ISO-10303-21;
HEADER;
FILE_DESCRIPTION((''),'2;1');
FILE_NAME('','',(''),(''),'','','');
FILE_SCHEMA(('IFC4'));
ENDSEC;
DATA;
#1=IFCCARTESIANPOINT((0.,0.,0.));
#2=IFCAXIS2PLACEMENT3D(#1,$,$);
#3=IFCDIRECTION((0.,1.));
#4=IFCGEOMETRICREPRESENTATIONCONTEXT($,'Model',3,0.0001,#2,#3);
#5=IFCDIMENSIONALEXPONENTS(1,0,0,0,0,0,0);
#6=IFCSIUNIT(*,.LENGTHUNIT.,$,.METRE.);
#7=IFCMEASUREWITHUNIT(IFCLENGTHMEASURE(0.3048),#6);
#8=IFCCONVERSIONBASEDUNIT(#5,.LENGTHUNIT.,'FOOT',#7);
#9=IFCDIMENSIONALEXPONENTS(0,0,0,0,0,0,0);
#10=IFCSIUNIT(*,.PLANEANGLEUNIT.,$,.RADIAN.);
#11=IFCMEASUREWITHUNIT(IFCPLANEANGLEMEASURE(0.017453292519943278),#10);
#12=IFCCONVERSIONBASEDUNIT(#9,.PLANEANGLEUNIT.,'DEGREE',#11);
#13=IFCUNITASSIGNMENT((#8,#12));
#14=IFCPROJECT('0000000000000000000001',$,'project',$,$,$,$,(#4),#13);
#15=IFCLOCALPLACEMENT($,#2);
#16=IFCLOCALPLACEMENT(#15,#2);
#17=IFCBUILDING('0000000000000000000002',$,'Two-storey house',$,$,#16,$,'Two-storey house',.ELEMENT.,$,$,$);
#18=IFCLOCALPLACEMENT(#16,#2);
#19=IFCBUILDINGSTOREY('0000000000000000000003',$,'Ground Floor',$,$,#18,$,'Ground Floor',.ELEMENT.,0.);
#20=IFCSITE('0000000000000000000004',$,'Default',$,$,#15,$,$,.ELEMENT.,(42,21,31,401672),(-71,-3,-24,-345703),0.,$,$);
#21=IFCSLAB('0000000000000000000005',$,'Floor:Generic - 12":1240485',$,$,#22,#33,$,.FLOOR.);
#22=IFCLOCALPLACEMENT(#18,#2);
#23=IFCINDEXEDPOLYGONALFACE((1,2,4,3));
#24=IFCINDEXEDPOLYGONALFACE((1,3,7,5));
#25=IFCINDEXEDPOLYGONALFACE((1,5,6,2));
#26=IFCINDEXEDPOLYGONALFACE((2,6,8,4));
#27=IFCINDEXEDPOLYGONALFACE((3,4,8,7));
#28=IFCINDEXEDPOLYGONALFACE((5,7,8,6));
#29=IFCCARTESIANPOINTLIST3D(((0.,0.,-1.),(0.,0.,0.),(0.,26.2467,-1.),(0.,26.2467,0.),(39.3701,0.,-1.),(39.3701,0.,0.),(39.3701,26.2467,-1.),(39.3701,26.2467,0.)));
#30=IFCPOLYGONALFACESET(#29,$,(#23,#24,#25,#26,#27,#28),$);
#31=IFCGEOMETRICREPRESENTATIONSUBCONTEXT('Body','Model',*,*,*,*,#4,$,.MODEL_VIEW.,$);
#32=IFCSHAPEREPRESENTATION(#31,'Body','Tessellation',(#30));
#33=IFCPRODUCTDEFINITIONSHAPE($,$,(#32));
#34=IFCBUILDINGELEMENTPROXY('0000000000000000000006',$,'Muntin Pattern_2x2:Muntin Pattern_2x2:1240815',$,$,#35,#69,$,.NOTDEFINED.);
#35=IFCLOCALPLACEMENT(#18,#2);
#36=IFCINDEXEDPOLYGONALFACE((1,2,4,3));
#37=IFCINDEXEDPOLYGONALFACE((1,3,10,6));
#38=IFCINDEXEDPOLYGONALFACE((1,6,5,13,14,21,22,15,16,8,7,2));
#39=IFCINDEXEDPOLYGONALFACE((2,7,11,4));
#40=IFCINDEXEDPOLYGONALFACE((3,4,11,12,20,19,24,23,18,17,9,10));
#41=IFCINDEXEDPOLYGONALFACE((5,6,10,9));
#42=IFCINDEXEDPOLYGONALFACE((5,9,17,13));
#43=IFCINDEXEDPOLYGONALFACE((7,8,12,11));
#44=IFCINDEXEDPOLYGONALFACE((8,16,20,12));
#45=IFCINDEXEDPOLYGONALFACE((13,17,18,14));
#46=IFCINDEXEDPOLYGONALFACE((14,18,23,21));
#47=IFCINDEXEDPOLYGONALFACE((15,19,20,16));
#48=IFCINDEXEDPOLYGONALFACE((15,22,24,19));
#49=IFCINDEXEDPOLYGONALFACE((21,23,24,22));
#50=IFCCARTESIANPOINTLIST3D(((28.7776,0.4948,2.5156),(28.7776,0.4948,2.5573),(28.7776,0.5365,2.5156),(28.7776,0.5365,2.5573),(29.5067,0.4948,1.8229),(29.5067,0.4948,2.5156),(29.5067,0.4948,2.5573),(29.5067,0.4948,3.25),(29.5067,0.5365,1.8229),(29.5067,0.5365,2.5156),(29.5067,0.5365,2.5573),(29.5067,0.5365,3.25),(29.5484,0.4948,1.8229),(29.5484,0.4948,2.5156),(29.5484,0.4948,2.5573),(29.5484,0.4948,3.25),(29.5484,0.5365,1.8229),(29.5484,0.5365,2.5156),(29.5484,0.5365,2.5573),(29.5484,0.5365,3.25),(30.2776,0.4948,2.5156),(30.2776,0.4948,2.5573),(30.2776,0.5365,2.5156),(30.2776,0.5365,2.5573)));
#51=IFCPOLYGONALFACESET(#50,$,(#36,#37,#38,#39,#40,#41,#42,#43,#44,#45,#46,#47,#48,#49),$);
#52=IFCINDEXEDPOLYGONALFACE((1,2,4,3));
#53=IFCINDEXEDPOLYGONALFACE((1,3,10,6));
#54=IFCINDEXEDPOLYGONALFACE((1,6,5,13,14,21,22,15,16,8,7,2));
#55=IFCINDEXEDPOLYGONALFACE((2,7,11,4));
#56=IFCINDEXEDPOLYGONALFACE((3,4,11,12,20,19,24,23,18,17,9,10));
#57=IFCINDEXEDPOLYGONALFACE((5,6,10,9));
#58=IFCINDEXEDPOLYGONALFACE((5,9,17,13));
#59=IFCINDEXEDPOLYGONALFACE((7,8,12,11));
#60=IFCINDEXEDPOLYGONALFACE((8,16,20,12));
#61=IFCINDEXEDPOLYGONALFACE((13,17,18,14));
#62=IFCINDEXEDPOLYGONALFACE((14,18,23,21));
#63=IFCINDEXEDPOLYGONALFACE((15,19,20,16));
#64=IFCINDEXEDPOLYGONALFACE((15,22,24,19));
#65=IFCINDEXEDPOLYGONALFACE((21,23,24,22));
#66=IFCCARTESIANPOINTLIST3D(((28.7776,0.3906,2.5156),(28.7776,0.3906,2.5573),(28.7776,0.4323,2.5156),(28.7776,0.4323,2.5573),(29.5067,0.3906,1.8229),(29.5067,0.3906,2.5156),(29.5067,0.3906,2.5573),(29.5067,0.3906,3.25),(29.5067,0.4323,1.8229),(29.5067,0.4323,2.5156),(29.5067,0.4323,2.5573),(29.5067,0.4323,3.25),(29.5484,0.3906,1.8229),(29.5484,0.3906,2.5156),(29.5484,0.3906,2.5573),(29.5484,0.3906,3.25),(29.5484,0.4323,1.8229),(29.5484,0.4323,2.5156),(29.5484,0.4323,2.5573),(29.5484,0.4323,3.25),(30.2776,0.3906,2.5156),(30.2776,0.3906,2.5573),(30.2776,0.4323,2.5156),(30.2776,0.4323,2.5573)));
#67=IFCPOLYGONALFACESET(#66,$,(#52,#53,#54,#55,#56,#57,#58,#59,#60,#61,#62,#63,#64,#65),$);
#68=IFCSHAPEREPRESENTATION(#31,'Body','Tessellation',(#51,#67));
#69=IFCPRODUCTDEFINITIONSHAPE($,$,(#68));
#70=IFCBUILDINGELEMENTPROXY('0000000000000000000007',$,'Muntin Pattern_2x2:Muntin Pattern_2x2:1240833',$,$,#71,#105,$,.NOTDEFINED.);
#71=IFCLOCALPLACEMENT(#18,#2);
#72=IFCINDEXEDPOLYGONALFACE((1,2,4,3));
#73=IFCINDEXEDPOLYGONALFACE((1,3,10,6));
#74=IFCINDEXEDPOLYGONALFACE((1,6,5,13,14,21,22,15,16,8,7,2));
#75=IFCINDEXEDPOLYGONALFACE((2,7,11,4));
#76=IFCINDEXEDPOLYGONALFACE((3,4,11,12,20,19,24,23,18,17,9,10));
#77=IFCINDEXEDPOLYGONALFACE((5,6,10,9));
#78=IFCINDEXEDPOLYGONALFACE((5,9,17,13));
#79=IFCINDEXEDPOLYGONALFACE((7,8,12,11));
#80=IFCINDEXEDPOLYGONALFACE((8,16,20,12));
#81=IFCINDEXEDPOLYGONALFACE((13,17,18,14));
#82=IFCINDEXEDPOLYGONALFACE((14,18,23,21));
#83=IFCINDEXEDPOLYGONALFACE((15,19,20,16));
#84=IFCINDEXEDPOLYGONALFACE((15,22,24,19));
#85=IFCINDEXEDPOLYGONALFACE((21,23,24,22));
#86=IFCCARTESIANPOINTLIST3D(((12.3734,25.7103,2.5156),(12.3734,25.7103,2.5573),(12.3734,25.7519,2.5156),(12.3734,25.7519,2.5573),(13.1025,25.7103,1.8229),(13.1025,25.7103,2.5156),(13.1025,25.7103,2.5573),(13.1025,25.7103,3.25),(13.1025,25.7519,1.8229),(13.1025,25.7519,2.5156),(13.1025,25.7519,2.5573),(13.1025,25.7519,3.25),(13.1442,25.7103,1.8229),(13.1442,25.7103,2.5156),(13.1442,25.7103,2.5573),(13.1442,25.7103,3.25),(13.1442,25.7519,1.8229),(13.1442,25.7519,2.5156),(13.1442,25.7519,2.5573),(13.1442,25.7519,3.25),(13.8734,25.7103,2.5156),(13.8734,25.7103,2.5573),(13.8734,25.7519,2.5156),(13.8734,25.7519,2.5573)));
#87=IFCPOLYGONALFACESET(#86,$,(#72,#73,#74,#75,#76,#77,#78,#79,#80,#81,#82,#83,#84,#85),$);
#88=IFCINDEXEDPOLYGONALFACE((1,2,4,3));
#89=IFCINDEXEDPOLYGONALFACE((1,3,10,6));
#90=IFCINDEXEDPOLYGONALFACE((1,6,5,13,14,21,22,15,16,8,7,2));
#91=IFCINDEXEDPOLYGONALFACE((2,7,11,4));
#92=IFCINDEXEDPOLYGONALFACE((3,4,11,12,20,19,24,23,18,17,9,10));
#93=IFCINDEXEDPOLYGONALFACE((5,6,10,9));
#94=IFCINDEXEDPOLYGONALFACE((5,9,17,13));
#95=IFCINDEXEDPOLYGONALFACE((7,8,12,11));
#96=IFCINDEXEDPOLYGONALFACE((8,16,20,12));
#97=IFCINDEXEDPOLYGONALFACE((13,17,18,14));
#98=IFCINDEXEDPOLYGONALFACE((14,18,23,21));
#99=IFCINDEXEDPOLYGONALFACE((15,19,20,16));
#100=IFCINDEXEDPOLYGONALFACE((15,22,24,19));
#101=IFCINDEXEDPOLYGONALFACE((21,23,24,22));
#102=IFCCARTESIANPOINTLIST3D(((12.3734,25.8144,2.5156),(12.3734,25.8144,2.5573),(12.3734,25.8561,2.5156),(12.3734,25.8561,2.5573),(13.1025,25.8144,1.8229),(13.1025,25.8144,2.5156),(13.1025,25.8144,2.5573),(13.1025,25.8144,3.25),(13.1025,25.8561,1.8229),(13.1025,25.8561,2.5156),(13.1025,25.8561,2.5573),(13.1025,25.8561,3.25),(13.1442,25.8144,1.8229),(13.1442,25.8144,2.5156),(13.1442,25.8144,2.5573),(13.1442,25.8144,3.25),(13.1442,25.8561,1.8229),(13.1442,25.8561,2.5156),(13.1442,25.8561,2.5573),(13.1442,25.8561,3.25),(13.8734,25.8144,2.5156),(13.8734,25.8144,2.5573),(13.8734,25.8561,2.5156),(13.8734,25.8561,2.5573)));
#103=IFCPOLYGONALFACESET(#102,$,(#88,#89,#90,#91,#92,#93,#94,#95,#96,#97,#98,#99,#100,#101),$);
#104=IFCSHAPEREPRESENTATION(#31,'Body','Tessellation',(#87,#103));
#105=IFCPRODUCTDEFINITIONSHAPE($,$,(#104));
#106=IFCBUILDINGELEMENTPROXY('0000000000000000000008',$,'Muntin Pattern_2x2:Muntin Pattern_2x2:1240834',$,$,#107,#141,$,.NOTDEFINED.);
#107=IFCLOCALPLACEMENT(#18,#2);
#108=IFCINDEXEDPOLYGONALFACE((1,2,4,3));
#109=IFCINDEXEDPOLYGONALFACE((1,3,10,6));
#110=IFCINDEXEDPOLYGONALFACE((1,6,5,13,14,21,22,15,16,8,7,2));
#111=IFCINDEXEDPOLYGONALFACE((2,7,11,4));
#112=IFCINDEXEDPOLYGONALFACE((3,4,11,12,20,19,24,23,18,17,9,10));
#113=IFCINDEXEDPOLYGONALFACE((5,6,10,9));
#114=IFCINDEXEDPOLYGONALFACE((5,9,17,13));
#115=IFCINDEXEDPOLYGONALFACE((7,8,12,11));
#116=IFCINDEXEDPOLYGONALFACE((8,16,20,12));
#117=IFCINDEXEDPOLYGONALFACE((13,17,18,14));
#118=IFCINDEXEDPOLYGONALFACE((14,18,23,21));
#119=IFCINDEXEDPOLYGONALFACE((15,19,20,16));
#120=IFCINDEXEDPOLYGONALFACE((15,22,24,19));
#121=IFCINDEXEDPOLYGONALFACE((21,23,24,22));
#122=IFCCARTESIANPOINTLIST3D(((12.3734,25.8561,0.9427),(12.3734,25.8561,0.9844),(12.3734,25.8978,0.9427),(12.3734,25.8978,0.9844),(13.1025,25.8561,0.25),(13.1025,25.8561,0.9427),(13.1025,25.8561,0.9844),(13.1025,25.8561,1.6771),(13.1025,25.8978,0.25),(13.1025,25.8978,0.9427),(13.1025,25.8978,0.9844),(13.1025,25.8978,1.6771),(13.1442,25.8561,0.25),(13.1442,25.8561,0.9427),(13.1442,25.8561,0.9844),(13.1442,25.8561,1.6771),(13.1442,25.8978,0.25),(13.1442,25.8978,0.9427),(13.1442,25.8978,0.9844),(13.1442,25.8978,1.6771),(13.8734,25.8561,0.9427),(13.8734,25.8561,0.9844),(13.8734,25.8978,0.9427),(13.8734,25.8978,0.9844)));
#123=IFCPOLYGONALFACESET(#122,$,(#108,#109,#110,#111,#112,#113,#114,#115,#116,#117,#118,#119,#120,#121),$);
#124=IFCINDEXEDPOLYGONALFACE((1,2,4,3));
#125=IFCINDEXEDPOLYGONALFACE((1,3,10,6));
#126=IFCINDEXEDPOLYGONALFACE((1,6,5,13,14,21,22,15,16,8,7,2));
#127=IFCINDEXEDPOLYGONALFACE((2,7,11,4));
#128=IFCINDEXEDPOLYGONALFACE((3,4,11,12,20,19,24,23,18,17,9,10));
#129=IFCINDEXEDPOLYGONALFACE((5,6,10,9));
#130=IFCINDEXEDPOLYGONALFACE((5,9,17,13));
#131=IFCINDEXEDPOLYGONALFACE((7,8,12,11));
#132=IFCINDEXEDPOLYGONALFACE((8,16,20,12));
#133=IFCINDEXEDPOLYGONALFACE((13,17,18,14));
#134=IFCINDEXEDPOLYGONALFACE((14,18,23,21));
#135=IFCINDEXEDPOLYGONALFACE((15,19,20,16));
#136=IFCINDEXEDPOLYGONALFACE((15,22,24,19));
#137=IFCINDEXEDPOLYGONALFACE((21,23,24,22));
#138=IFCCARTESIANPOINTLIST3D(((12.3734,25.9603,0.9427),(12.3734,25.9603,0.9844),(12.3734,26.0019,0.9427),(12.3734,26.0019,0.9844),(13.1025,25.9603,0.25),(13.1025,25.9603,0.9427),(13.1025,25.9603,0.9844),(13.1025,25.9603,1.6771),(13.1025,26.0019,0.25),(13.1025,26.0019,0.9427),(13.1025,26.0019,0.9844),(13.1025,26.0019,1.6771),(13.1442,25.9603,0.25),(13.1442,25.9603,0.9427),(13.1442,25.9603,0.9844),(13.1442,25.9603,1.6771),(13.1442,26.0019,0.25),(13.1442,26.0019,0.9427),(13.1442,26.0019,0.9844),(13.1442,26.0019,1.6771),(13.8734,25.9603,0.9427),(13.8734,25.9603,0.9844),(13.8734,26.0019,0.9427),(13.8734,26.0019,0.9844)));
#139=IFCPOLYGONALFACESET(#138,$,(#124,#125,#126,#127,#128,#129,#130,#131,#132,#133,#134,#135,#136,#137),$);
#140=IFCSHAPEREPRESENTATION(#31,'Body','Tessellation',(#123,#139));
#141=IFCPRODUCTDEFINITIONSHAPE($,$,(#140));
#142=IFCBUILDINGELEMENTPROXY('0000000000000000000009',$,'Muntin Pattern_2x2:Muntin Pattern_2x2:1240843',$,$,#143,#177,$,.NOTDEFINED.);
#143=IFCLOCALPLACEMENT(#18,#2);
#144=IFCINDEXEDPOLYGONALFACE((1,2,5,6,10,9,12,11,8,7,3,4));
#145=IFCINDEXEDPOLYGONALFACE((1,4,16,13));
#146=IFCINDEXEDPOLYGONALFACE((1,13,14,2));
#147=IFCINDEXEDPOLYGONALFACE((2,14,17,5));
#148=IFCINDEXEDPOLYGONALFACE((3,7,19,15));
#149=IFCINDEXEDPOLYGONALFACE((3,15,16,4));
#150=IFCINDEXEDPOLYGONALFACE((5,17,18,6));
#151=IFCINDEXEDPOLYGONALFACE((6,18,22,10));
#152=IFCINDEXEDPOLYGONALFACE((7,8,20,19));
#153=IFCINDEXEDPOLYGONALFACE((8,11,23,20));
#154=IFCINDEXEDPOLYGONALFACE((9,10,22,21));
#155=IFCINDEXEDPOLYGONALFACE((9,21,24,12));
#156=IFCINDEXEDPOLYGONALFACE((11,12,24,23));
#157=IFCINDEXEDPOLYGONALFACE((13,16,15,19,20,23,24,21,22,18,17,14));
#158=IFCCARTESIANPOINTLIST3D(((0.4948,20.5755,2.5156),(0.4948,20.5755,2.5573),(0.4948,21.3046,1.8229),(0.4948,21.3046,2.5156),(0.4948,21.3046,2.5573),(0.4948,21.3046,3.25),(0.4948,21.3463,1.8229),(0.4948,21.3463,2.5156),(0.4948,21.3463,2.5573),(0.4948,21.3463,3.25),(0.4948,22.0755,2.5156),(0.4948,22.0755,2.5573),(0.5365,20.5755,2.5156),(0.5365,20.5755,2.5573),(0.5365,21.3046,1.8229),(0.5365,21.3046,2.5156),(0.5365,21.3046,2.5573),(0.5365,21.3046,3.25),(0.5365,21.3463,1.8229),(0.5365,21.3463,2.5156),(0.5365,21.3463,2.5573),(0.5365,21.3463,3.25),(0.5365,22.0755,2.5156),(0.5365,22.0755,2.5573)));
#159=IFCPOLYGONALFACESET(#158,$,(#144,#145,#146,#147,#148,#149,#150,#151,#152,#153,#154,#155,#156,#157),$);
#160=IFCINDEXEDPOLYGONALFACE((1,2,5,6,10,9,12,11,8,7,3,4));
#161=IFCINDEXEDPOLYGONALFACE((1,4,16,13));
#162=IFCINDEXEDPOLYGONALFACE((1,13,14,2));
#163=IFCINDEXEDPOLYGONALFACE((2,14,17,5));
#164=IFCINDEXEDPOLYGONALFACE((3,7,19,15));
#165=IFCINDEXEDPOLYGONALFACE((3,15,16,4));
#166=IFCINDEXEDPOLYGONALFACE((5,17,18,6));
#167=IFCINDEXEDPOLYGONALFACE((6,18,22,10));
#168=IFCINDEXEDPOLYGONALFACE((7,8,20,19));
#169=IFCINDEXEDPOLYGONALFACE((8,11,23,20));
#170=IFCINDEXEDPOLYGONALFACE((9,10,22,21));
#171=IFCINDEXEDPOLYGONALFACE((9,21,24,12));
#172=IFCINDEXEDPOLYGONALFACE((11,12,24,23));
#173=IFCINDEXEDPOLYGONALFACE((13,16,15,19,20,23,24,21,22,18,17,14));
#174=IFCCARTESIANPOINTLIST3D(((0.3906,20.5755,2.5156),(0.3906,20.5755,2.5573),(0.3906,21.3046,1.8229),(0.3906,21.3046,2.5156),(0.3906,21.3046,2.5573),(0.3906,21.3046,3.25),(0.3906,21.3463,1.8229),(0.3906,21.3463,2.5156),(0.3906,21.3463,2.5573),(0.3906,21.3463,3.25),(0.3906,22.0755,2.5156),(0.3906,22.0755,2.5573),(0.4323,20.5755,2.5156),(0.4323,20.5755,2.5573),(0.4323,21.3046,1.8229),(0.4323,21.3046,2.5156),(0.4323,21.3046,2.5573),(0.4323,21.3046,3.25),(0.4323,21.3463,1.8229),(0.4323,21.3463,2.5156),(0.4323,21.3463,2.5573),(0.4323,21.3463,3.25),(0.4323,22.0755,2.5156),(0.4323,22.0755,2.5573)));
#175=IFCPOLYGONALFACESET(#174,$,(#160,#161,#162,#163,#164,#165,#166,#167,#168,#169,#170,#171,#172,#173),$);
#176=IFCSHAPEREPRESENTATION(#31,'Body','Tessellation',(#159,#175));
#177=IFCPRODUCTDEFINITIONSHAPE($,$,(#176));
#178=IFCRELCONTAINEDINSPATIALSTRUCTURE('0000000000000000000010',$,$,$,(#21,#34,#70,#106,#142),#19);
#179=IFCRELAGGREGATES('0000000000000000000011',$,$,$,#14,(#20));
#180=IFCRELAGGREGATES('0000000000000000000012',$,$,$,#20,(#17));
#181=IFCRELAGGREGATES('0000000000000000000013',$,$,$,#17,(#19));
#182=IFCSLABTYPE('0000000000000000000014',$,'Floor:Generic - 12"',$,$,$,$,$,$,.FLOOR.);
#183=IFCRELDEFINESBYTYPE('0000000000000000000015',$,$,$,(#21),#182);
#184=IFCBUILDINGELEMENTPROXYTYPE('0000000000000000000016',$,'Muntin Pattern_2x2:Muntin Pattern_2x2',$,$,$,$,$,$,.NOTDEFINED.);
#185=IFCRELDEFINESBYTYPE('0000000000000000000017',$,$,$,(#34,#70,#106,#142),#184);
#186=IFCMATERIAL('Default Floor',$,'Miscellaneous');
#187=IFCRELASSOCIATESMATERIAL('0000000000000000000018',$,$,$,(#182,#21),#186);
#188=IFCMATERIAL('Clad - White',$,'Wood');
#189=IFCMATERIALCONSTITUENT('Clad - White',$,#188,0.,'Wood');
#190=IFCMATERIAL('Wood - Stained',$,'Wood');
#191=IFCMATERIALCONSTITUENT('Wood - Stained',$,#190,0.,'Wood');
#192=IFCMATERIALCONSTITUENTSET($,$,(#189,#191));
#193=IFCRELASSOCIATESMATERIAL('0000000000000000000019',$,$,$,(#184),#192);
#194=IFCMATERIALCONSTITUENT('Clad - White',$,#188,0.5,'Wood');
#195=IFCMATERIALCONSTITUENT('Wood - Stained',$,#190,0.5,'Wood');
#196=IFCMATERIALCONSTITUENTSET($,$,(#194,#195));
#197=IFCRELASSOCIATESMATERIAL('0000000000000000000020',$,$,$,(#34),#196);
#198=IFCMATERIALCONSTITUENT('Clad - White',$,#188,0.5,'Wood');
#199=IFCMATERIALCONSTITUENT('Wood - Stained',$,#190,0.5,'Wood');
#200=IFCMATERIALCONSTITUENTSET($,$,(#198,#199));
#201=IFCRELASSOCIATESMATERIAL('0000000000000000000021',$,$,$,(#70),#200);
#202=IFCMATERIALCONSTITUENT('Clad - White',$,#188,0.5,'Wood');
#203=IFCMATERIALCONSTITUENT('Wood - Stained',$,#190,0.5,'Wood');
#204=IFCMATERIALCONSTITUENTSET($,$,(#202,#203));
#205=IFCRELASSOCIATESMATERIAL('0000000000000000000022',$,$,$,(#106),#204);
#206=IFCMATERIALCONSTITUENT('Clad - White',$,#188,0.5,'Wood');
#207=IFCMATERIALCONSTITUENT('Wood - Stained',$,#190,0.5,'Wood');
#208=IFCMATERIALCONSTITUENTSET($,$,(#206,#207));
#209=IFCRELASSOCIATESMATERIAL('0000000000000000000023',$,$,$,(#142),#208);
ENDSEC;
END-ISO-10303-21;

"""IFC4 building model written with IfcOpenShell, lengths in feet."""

from ifc_helpers import new_model, entity, si_unit, converted_unit, direction, frame, origin, place, context, subcontext, project, spatial, indexed_curve, outline, extrude, source, transform, mapped, material, constituent, constituent_set, type_object, type_shapes, element, save


model = new_model("IFC4")

# Units and contexts
model_context = context("Model", 3, precision=0.0001, world=origin(), true_north=direction((0.0, 1.0)))
body_context = subcontext(model_context, "Body", "Model", "MODEL_VIEW")
ifc_project = project(units=[converted_unit("LENGTHUNIT", "FOOT", entity("IfcLengthMeasure", 0.3048), si_unit("LENGTHUNIT", "METRE"), dimensions=[1, 0, 0, 0, 0, 0, 0]), converted_unit("PLANEANGLEUNIT", "DEGREE", entity("IfcPlaneAngleMeasure", 0.017453292519943278), si_unit("PLANEANGLEUNIT", "RADIAN"), dimensions=[0, 0, 0, 0, 0, 0, 0])], contexts=[model_context])

# Site, building, storey
site_placement = place(None, origin())
site = spatial("IfcSite", under=ifc_project, at=site_placement, Name="Default", CompositionType="ELEMENT", RefLatitude=(42, 21, 31, 401672), RefLongitude=(-71, -3, -24, -345703), RefElevation=0.0)
building_placement = place(site_placement, origin())
building = spatial("IfcBuilding", under=site, at=building_placement, Name="Two-storey house", LongName="Two-storey house", CompositionType="ELEMENT")
storey_placement = place(building_placement, origin())
storey = spatial("IfcBuildingStorey", under=building, at=storey_placement, Name="Ground Floor", LongName="Ground Floor", CompositionType="ELEMENT", Elevation=0.0)

# Slab
ifc_material_1 = material(Name="Default Floor", Category="Miscellaneous")
slab_type = type_object("IfcSlabType", Name="Floor:Generic - 12\"", PredefinedType="FLOOR", material=ifc_material_1)
slab_placement = place(storey_placement, origin())
element("IfcSlab", 1, at=slab_placement, inside=storey, type_object=slab_type, material=ifc_material_1, Name="Floor:Generic - 12\":1240485", PredefinedType="FLOOR", context=body_context, shape_type="SweptSolid", body=[
    extrude(outline(indexed_curve([(-13.1234, -19.685), (13.1234, -19.685), (13.1234, 19.685), (-13.1234, 19.685), (-13.1234, -19.685)], self_intersect=False)), frame((19.685, 13.1234, 0.0), z_axis=(0.0, 0.0, -1.0), x_axis=(0.0, 1.0, 0.0)), (0.0, 0.0, 1.0), 1.0),
])

# Shared definitions
ifc_material_2 = material(Name="Wood - Stained", Category="Wood")

# Building element proxies
ifc_material_3 = material(Name="Clad - White", Category="Wood")
ifc_constituent_1 = constituent(ifc_material_3, Name="Clad - White", Category="Wood", fraction=0.5)
ifc_constituent_2 = constituent(ifc_material_2, Name="Wood - Stained", Category="Wood", fraction=0.5)
ifc_constituent_set_1 = constituent_set(constituents=[ifc_constituent_1, ifc_constituent_2])
ifc_constituent_3 = constituent(ifc_material_3, Name="Clad - White", Category="Wood", fraction=0.0)
ifc_constituent_4 = constituent(ifc_material_2, Name="Wood - Stained", Category="Wood", fraction=0.0)
ifc_constituent_set_2 = constituent_set(constituents=[ifc_constituent_3, ifc_constituent_4])
building_element_proxy_type_1 = type_object("IfcBuildingElementProxyType", Name="Muntin Pattern_2x2:Muntin Pattern_2x2", PredefinedType="NOTDEFINED", material=ifc_constituent_set_2)
shared_shape_1 = source(origin(), body_context, "Body", "SweptSolid", [
    extrude(outline(indexed_curve([(0.0208, -0.0208), (0.7135, -0.0208), (0.7135, 0.0208), (0.0208, 0.0208), (0.0208, 0.75), (-0.0208, 0.75), (-0.0208, 0.0208), (-0.7135, 0.0208), (-0.7135, -0.0208), (-0.0208, -0.0208), (-0.0208, -0.75), (0.0208, -0.75), (0.0208, -0.0208)], self_intersect=False)), frame((0.0, 0.0312, 0.7135), z_axis=(0.0, 1.0, 0.0), x_axis=(0.0, 0.0, 1.0)), (0.0, 0.0, 1.0), 0.0417),
    extrude(outline(indexed_curve([(0.0208, -0.0208), (0.7135, -0.0208), (0.7135, 0.0208), (0.0208, 0.0208), (0.0208, 0.75), (-0.0208, 0.75), (-0.0208, 0.0208), (-0.7135, 0.0208), (-0.7135, -0.0208), (-0.0208, -0.0208), (-0.0208, -0.75), (0.0208, -0.75), (0.0208, -0.0208)], self_intersect=False)), frame((0.0, -0.0729, 0.7135), z_axis=(0.0, 1.0, 0.0), x_axis=(0.0, 0.0, 1.0)), (0.0, 0.0, 1.0), 0.0417),
])
type_shapes(building_element_proxy_type_1, [shared_shape_1])
proxy_1_placement = place(storey_placement, frame((29.5276, 0.4635, 1.8229)))
element("IfcBuildingElementProxy", 2, at=proxy_1_placement, inside=storey, type_object=building_element_proxy_type_1, material=ifc_constituent_set_1, Name="Muntin Pattern_2x2:Muntin Pattern_2x2:1240815", PredefinedType="NOTDEFINED", context=body_context, shape_type="MappedRepresentation", body=[
    mapped(shared_shape_1, transform((0.0, 0.0, 0.0), scale=1.0)),
])
ifc_constituent_5 = constituent(ifc_material_3, Name="Clad - White", Category="Wood", fraction=0.5)
ifc_constituent_6 = constituent(ifc_material_2, Name="Wood - Stained", Category="Wood", fraction=0.5)
ifc_constituent_set_3 = constituent_set(constituents=[ifc_constituent_5, ifc_constituent_6])
proxy_2_placement = place(storey_placement, frame((13.1234, 25.7832, 1.8229), z_axis=(0.0, 0.0, 1.0), x_axis=(-1.0, 0.0, 0.0)))
element("IfcBuildingElementProxy", 3, at=proxy_2_placement, inside=storey, type_object=building_element_proxy_type_1, material=ifc_constituent_set_3, Name="Muntin Pattern_2x2:Muntin Pattern_2x2:1240833", PredefinedType="NOTDEFINED", context=body_context, shape_type="MappedRepresentation", body=[
    mapped(shared_shape_1, transform((0.0, 0.0, 0.0), scale=1.0)),
])
ifc_constituent_7 = constituent(ifc_material_3, Name="Clad - White", Category="Wood", fraction=0.5)
ifc_constituent_8 = constituent(ifc_material_2, Name="Wood - Stained", Category="Wood", fraction=0.5)
ifc_constituent_set_4 = constituent_set(constituents=[ifc_constituent_7, ifc_constituent_8])
proxy_3_placement = place(storey_placement, frame((13.1234, 25.929, 0.25), z_axis=(0.0, 0.0, 1.0), x_axis=(-1.0, 0.0, 0.0)))
element("IfcBuildingElementProxy", 4, at=proxy_3_placement, inside=storey, type_object=building_element_proxy_type_1, material=ifc_constituent_set_4, Name="Muntin Pattern_2x2:Muntin Pattern_2x2:1240834", PredefinedType="NOTDEFINED", context=body_context, shape_type="MappedRepresentation", body=[
    mapped(shared_shape_1, transform((0.0, 0.0, 0.0), scale=1.0)),
])
ifc_constituent_9 = constituent(ifc_material_3, Name="Clad - White", Category="Wood", fraction=0.5)
ifc_constituent_10 = constituent(ifc_material_2, Name="Wood - Stained", Category="Wood", fraction=0.5)
ifc_constituent_set_5 = constituent_set(constituents=[ifc_constituent_9, ifc_constituent_10])
proxy_4_placement = place(storey_placement, frame((0.4635, 21.3255, 1.8229), z_axis=(0.0, 0.0, 1.0), x_axis=(0.0, -1.0, 0.0)))
element("IfcBuildingElementProxy", 5, at=proxy_4_placement, inside=storey, type_object=building_element_proxy_type_1, material=ifc_constituent_set_5, Name="Muntin Pattern_2x2:Muntin Pattern_2x2:1240843", PredefinedType="NOTDEFINED", context=body_context, shape_type="MappedRepresentation", body=[
    mapped(shared_shape_1, transform((0.0, 0.0, 0.0), scale=1.0)),
])

save(model, "model.ifc")
